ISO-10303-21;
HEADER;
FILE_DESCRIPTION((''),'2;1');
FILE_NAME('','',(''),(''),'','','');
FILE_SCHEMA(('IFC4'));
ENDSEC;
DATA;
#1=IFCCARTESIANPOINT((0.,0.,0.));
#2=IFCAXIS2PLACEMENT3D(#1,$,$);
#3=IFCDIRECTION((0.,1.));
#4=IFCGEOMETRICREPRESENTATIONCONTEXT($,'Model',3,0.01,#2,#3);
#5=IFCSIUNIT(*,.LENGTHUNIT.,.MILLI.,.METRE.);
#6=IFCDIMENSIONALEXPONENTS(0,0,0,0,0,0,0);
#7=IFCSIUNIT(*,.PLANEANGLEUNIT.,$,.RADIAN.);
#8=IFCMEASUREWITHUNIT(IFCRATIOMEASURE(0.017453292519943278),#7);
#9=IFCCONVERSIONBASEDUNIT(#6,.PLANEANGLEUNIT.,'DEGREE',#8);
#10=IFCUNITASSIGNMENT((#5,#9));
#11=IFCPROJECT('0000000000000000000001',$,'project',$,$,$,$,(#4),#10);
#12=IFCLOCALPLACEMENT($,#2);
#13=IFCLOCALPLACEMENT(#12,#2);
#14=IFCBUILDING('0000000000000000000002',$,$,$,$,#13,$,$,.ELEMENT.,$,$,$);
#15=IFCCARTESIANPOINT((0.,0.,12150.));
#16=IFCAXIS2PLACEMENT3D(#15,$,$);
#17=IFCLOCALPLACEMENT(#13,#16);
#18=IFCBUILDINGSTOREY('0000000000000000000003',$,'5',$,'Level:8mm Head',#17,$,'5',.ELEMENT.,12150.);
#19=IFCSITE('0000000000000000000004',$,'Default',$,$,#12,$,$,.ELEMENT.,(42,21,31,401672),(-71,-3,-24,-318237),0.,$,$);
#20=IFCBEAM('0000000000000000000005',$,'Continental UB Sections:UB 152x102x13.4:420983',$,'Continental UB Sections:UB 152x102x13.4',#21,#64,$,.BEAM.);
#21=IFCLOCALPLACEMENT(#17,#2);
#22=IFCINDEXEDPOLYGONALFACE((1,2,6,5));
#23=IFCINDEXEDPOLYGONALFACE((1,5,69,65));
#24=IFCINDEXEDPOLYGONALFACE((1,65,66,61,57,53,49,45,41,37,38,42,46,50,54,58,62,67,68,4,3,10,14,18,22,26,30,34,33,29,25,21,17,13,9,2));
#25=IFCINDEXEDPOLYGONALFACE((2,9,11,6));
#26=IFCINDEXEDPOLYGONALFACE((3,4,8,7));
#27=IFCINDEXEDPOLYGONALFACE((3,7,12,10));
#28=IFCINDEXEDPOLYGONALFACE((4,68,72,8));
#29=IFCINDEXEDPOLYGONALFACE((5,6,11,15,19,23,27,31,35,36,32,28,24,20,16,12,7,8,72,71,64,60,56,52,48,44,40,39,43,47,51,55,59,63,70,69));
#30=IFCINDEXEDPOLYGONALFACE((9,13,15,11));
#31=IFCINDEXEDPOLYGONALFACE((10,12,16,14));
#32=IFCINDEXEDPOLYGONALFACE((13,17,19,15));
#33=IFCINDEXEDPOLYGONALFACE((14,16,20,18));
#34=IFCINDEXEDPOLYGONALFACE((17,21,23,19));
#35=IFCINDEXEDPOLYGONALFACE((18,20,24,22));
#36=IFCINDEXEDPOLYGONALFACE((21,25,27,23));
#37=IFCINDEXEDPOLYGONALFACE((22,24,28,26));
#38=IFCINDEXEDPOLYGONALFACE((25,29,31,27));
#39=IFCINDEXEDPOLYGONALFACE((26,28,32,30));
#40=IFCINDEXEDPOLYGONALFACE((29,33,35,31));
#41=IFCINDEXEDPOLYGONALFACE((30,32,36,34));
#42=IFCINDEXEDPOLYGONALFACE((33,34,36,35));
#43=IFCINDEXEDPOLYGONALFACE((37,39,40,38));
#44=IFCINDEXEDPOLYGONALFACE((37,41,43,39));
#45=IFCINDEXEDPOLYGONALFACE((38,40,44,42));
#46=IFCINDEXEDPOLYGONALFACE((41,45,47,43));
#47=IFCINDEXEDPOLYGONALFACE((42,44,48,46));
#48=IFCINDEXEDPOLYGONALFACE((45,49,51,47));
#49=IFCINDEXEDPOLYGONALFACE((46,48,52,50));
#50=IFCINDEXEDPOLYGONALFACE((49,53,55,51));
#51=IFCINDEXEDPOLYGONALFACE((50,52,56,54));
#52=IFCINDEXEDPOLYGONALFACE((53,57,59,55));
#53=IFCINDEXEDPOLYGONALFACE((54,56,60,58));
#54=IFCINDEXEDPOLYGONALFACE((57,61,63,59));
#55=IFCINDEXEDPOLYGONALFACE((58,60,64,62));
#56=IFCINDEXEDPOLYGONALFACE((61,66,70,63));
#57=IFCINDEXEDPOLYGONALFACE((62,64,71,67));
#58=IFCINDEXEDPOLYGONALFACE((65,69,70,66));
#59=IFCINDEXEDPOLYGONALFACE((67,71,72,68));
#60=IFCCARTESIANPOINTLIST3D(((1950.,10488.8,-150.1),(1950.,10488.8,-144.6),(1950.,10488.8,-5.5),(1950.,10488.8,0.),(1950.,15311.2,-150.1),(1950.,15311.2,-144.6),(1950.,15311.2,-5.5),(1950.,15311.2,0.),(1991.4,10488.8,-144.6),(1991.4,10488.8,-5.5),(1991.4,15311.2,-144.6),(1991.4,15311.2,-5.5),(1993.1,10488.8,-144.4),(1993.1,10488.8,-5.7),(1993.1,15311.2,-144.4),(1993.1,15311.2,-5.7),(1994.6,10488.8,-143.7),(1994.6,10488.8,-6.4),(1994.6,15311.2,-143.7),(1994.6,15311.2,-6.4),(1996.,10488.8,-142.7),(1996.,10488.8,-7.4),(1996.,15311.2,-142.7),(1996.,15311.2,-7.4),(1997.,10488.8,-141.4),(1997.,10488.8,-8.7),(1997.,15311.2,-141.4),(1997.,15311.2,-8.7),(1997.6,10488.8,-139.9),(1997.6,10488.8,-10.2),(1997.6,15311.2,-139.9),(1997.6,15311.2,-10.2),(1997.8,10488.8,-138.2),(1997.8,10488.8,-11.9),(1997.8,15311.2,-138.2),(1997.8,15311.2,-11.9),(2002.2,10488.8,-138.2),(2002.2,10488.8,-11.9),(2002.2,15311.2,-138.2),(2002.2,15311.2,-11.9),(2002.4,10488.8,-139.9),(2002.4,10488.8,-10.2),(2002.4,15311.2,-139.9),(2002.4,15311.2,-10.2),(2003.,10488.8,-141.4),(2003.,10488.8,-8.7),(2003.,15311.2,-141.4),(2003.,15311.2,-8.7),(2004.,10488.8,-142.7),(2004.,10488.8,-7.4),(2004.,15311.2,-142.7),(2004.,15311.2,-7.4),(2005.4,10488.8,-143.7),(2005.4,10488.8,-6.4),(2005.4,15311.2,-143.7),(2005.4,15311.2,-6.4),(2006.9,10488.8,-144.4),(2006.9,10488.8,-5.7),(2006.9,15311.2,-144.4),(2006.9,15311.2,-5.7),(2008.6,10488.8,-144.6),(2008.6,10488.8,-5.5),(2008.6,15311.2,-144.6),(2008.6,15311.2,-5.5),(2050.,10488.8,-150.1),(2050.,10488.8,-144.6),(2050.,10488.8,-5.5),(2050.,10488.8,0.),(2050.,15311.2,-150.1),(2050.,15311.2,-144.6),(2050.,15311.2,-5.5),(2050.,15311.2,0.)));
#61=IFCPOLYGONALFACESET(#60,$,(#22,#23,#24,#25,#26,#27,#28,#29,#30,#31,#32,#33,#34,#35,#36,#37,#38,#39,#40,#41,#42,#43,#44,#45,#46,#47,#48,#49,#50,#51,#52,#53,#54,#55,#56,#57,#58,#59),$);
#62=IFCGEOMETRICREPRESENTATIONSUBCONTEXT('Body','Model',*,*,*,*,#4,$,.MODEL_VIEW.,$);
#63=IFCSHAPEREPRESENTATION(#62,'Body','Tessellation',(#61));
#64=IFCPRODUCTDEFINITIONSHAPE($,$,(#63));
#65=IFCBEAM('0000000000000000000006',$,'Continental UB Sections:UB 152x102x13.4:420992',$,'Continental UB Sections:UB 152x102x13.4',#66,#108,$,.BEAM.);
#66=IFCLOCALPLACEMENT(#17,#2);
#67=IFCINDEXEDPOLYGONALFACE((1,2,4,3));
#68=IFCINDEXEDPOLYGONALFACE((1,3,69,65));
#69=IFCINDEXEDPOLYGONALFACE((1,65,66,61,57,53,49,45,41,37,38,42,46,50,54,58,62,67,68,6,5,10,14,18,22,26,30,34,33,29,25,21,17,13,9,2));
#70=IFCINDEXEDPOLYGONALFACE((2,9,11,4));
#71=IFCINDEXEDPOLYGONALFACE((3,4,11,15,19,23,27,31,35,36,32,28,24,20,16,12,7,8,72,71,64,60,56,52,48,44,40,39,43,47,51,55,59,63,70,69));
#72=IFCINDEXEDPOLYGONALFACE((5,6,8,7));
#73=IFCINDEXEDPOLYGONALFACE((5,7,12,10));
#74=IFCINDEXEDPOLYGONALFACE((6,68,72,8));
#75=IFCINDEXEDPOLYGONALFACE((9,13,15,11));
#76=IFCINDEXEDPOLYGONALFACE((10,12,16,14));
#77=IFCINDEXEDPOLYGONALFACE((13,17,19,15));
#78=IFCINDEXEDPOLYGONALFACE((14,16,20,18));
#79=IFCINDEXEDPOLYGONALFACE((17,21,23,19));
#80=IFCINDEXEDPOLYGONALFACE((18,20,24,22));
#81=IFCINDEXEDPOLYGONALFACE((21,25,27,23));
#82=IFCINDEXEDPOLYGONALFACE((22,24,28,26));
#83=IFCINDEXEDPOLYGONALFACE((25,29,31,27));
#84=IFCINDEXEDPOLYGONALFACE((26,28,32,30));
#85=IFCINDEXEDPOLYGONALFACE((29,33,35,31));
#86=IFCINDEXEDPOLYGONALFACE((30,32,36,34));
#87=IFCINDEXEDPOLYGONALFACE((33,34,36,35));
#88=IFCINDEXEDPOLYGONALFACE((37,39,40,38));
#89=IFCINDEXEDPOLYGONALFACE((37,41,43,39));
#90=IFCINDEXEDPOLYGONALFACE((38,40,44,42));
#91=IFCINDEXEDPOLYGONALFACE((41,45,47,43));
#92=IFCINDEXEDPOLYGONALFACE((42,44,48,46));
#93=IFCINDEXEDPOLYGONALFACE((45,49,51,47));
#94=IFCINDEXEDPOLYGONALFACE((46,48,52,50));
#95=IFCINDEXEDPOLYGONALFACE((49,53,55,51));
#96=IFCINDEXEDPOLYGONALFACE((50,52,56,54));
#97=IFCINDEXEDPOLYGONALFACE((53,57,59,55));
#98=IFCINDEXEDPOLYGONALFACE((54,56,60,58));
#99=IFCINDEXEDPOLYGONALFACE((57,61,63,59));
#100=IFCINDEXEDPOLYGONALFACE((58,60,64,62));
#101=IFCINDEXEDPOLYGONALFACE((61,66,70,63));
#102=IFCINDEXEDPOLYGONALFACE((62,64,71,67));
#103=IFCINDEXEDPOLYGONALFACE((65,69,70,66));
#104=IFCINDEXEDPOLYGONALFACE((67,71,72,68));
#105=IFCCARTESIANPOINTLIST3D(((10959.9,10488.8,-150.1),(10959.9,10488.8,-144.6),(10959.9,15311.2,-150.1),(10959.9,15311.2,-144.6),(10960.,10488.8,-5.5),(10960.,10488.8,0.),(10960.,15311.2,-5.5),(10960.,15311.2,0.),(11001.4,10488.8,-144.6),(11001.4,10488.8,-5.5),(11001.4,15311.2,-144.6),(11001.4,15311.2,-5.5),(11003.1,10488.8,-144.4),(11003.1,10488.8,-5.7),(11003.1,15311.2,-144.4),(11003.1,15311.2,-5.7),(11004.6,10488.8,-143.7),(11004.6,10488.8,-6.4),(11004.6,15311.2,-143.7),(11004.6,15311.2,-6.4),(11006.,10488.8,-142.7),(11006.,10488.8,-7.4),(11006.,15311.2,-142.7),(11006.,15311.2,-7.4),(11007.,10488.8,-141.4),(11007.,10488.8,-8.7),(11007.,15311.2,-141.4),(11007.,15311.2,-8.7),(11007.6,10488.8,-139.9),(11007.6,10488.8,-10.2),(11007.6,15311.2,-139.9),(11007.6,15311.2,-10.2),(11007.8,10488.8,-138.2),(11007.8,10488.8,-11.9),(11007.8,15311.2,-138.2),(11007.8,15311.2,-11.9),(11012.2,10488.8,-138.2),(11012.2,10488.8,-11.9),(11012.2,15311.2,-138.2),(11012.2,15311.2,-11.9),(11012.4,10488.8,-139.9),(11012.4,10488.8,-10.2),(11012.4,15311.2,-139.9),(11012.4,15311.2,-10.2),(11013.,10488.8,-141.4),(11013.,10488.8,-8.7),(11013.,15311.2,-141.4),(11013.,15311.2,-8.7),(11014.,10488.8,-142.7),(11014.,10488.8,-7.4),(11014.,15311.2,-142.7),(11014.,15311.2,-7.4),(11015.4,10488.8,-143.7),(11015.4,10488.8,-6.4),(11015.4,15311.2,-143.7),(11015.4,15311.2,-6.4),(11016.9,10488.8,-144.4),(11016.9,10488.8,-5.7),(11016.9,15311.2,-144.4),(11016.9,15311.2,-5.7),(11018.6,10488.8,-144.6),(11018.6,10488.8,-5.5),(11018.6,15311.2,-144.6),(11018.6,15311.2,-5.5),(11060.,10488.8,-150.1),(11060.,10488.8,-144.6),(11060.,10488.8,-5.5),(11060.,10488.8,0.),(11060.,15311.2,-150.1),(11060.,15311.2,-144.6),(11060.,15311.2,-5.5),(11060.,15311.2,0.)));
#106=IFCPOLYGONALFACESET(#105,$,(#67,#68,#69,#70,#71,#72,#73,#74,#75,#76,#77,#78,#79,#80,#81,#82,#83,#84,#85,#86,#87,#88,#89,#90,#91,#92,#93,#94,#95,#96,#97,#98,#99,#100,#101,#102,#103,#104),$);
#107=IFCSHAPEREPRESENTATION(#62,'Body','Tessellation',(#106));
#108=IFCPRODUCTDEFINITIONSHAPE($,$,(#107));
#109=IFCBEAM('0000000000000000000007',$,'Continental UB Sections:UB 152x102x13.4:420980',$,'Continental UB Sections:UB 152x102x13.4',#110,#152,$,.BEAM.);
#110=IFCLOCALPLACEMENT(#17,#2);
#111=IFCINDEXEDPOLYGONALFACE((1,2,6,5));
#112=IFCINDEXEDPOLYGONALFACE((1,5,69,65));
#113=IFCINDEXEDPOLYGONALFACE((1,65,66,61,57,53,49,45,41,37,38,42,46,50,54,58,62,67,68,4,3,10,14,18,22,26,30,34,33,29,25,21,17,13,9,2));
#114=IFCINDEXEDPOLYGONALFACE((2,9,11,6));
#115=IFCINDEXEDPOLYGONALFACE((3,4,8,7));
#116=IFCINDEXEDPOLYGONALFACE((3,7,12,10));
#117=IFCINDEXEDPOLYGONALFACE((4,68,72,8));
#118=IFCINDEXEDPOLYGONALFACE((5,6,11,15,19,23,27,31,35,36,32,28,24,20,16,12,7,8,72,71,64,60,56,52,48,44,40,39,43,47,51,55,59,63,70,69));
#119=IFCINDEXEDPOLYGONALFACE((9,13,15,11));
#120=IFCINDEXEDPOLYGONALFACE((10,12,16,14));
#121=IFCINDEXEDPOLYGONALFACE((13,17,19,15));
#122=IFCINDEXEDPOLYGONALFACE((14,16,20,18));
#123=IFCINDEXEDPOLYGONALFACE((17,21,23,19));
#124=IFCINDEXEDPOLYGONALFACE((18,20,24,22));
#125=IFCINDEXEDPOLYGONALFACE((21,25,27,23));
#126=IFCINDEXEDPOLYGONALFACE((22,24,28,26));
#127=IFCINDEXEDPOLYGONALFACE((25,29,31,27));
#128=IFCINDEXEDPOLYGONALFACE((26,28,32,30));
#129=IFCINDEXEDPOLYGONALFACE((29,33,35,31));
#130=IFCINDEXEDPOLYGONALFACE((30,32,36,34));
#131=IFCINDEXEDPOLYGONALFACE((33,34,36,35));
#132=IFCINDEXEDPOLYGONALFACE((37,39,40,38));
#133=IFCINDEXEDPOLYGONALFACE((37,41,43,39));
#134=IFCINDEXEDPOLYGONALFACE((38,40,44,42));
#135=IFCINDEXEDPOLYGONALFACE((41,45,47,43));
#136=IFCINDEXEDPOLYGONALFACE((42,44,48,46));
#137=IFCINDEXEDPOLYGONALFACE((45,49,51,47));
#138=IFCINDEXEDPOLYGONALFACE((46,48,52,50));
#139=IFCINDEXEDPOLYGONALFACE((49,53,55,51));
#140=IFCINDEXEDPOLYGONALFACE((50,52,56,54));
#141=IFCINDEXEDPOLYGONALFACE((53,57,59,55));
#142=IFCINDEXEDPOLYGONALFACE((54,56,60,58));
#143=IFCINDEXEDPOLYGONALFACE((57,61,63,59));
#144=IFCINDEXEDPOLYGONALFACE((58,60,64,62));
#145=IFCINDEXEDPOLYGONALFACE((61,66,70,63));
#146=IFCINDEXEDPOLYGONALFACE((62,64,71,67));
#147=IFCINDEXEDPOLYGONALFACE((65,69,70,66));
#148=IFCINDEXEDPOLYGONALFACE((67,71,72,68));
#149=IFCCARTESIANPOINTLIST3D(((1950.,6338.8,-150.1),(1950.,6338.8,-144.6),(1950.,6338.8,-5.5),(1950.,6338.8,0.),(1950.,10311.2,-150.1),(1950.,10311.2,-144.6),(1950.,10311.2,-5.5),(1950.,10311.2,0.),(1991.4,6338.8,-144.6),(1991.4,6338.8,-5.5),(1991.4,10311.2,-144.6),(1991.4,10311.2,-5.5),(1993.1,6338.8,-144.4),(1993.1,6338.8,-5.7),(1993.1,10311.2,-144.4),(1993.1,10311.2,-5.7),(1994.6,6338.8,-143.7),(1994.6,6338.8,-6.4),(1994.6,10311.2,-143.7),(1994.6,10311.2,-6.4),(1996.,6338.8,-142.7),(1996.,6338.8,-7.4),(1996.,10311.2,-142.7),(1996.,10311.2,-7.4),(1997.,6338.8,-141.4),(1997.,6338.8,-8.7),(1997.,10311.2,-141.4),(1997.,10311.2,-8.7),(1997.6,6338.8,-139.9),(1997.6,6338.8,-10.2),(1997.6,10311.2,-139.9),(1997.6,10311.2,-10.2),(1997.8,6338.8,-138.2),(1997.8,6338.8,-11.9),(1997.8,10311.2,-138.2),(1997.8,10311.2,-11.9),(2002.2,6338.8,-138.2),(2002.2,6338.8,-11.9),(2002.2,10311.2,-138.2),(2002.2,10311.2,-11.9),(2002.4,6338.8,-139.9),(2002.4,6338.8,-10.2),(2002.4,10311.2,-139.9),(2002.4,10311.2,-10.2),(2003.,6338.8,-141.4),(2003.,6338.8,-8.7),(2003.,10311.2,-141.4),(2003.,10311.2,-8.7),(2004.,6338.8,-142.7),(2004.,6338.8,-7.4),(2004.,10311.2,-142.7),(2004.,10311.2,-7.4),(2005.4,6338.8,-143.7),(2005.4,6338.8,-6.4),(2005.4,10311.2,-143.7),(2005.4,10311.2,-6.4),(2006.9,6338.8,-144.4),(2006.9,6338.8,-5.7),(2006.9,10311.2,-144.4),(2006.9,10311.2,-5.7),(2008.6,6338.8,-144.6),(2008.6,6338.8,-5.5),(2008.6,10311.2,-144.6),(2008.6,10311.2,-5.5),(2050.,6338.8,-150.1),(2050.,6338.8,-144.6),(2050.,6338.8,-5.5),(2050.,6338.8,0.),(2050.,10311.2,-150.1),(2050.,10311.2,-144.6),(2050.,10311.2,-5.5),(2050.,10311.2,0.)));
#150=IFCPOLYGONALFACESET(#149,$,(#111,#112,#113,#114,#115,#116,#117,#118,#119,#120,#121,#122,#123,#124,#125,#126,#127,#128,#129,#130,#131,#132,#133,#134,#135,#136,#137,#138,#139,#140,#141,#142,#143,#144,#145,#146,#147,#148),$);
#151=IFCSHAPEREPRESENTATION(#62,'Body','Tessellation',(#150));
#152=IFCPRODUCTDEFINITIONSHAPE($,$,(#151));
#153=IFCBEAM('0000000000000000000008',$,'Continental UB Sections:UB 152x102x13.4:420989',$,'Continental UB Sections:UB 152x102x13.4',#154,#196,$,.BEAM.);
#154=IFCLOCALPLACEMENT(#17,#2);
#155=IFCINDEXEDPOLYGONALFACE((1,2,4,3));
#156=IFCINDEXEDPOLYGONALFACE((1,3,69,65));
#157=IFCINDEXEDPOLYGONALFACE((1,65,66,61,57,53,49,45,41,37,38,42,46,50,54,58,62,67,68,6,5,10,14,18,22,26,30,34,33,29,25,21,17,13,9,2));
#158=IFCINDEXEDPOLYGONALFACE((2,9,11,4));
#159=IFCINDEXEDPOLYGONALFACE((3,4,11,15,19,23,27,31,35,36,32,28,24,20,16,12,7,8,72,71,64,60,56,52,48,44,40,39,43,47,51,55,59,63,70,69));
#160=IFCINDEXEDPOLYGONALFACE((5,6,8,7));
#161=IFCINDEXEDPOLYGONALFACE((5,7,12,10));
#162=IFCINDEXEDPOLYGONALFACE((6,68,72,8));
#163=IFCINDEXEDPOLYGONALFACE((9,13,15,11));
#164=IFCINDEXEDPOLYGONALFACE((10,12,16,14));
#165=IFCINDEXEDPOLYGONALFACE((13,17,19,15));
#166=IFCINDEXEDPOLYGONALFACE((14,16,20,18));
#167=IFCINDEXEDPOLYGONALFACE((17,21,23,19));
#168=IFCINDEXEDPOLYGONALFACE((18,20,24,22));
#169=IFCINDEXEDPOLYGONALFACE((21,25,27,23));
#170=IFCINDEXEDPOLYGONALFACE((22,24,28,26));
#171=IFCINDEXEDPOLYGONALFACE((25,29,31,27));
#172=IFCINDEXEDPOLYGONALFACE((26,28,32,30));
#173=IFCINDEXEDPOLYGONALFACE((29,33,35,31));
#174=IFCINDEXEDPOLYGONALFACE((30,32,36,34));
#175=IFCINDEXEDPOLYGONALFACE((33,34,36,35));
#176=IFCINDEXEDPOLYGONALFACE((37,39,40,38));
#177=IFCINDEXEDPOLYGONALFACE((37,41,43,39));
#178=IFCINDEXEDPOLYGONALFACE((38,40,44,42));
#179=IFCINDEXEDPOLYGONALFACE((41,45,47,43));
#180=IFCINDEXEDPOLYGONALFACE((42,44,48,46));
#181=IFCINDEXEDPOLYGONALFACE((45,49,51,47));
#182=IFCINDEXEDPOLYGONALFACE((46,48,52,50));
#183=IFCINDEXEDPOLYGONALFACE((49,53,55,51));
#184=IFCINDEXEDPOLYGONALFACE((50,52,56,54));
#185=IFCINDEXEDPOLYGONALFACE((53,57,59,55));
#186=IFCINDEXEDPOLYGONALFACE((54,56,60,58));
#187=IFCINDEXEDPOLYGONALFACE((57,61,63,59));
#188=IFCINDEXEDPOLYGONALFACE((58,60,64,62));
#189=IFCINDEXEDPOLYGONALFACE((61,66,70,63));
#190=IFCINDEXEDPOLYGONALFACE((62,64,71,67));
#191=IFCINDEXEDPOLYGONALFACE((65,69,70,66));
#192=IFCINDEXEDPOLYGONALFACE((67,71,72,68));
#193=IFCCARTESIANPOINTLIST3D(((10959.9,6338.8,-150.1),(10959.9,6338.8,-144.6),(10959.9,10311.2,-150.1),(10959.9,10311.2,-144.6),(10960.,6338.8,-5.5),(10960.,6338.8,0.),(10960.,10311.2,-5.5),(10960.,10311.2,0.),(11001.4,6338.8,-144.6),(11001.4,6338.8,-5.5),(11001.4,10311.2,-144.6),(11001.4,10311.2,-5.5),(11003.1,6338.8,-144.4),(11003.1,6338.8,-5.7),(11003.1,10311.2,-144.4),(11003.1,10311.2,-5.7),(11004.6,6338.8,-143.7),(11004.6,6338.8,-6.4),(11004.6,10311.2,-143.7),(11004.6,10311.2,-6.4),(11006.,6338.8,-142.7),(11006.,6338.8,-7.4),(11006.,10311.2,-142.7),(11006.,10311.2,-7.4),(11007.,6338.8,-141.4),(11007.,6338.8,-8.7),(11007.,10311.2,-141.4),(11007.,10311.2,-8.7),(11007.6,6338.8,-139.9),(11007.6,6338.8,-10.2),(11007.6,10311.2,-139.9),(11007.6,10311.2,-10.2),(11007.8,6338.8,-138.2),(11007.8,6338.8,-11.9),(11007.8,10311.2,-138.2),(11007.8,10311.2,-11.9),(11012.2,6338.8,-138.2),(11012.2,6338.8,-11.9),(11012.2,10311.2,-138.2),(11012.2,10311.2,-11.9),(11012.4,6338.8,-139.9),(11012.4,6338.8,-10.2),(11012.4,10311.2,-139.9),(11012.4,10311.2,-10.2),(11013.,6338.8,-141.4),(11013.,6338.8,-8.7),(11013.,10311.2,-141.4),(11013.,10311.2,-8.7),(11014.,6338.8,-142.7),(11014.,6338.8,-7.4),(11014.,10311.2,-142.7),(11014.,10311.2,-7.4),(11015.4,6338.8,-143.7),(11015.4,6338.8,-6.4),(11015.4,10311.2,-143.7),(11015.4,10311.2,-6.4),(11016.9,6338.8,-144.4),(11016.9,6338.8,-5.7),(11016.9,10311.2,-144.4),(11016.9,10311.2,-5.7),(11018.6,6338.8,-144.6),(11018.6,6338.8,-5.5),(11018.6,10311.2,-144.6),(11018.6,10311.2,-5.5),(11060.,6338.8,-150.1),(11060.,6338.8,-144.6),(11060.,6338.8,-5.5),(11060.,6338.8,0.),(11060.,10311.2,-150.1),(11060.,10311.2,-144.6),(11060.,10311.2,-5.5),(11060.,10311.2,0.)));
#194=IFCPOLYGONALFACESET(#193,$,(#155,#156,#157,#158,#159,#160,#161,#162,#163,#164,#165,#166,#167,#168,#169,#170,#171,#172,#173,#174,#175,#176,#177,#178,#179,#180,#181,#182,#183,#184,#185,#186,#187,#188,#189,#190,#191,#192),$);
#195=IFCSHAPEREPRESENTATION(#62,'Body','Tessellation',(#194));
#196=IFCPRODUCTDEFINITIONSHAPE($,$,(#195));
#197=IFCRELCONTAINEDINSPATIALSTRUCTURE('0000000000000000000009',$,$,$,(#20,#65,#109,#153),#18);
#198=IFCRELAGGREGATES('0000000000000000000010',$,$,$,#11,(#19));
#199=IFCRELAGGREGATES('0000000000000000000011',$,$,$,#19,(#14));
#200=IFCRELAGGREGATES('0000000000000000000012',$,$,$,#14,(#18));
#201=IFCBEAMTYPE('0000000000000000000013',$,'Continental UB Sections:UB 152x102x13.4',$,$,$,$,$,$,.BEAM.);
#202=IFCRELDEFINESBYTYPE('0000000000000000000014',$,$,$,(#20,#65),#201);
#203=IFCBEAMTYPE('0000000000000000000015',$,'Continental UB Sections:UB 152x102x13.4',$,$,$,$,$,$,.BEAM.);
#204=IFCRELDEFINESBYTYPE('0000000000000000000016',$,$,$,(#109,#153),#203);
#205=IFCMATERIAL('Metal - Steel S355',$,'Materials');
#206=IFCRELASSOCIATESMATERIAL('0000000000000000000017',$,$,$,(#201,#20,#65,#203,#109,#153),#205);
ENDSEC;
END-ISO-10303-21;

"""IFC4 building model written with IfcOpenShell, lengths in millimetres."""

from ifc_helpers import new_model, entity, si_unit, converted_unit, direction, frame, origin, place, context, subcontext, project, spatial, line, arc, indexed_curve, outline, extrude, source, transform, mapped, material, type_object, type_shapes, element, save


model = new_model("IFC4")

# Units and contexts
model_context = context("Model", 3, precision=0.01, world=origin(), true_north=direction((0.0, 1.0)))
body_context = subcontext(model_context, "Body", "Model", "MODEL_VIEW")
ifc_project = project(units=[si_unit("LENGTHUNIT", "METRE", prefix="MILLI"), converted_unit("PLANEANGLEUNIT", "DEGREE", entity("IfcRatioMeasure", 0.017453292519943278), si_unit("PLANEANGLEUNIT", "RADIAN"), dimensions=[0, 0, 0, 0, 0, 0, 0])], contexts=[model_context])

# Site, building, storey
site_placement = place(None, origin())
site = spatial("IfcSite", under=ifc_project, at=site_placement, Name="Default", CompositionType="ELEMENT", RefLatitude=(42, 21, 31, 401672), RefLongitude=(-71, -3, -24, -318237), RefElevation=0.0)
building_placement = place(site_placement, origin())
building = spatial("IfcBuilding", under=site, at=building_placement, CompositionType="ELEMENT")
storey_placement = place(building_placement, frame((0.0, 0.0, 12150.0)))
storey = spatial("IfcBuildingStorey", under=building, at=storey_placement, Name="5", ObjectType="Level:8mm Head", LongName="5", CompositionType="ELEMENT", Elevation=12150.0)

# Beams
ifc_material = material(Name="Metal - Steel S355", Category="Materials")
beam_type_1 = type_object("IfcBeamType", Name="Continental UB Sections:UB 152x102x13.4", PredefinedType="BEAM", material=ifc_material)
shared_shape_1 = source(origin(), body_context, "Body", "SweptSolid", [
    extrude(outline(indexed_curve([(-75.0, -50.1), (-69.6, -50.1), (-69.6, -8.5), (-67.7, -4.0), (-63.2, -2.1), (63.1, -2.1), (67.7, -4.0), (69.5, -8.5), (69.5, -50.1), (75.1, -50.1), (75.1, 50.1), (69.5, 50.1), (69.5, 8.6), (67.7, 4.0), (63.1, 2.2), (-63.2, 2.2), (-67.7, 4.0), (-69.6, 8.6), (-69.6, 50.0), (-75.0, 50.0)], segments=[line(1, 2, 3), arc(3, 4, 5), line(5, 6), arc(6, 7, 8), line(8, 9, 10, 11, 12, 13), arc(13, 14, 15), line(15, 16), arc(16, 17, 18), line(18, 19, 20, 1)], self_intersect=False)), frame((-2411.2, 0.0, 0.0), z_axis=(1.0, 0.0, 0.0), x_axis=(0.0, 0.0, -1.0)), (0.0, 0.0, 1.0), 4822.4),
])
type_shapes(beam_type_1, [shared_shape_1])
for number, where, z_axis, x_axis, name in (
    (1, (2000.0, 12900.0, -75.1), (0.0, 0.0, 1.0), (0.0, 1.0, 0.0), "Continental UB Sections:UB 152x102x13.4:420983"),
    (2, (11010.0, 12900.0, -75.1), (0.0, 0.0, 1.0), (0.0, 1.0, 0.0), "Continental UB Sections:UB 152x102x13.4:420992"),
):
    element("IfcBeam", number, at=place(storey_placement, frame(where, z_axis=z_axis, x_axis=x_axis)), inside=storey, type_object=beam_type_1, material=ifc_material, Name=name, ObjectType="Continental UB Sections:UB 152x102x13.4", PredefinedType="BEAM", context=body_context, shape_type="MappedRepresentation", body=[
        mapped(shared_shape_1, transform((0.0, 0.0, 0.0), scale=1.0)),
    ])
beam_type_2 = type_object("IfcBeamType", Name="Continental UB Sections:UB 152x102x13.4", PredefinedType="BEAM", material=ifc_material)
shared_shape_2 = source(origin(), body_context, "Body", "SweptSolid", [
    extrude(outline(indexed_curve([(-75.0, -50.1), (-69.6, -50.1), (-69.6, -8.5), (-67.7, -4.0), (-63.2, -2.1), (63.1, -2.1), (67.7, -4.0), (69.5, -8.5), (69.5, -50.1), (75.1, -50.1), (75.1, 50.1), (69.5, 50.1), (69.5, 8.6), (67.7, 4.0), (63.1, 2.2), (-63.2, 2.2), (-67.7, 4.0), (-69.6, 8.6), (-69.6, 50.0), (-75.0, 50.0)], segments=[line(1, 2, 3), arc(3, 4, 5), line(5, 6), arc(6, 7, 8), line(8, 9, 10, 11, 12, 13), arc(13, 14, 15), line(15, 16), arc(16, 17, 18), line(18, 19, 20, 1)], self_intersect=False)), frame((-1986.2, 0.0, 0.0), z_axis=(1.0, 0.0, 0.0), x_axis=(0.0, 0.0, -1.0)), (0.0, 0.0, 1.0), 3972.4),
])
type_shapes(beam_type_2, [shared_shape_2])
for number, where, z_axis, x_axis, name in (
    (3, (2000.0, 8325.0, -75.1), (0.0, 0.0, 1.0), (0.0, 1.0, 0.0), "Continental UB Sections:UB 152x102x13.4:420980"),
    (4, (11010.0, 8325.0, -75.1), (0.0, 0.0, 1.0), (0.0, 1.0, 0.0), "Continental UB Sections:UB 152x102x13.4:420989"),
):
    element("IfcBeam", number, at=place(storey_placement, frame(where, z_axis=z_axis, x_axis=x_axis)), inside=storey, type_object=beam_type_2, material=ifc_material, Name=name, ObjectType="Continental UB Sections:UB 152x102x13.4", PredefinedType="BEAM", context=body_context, shape_type="MappedRepresentation", body=[
        mapped(shared_shape_2, transform((0.0, 0.0, 0.0), scale=1.0)),
    ])

save(model, "model.ifc")
